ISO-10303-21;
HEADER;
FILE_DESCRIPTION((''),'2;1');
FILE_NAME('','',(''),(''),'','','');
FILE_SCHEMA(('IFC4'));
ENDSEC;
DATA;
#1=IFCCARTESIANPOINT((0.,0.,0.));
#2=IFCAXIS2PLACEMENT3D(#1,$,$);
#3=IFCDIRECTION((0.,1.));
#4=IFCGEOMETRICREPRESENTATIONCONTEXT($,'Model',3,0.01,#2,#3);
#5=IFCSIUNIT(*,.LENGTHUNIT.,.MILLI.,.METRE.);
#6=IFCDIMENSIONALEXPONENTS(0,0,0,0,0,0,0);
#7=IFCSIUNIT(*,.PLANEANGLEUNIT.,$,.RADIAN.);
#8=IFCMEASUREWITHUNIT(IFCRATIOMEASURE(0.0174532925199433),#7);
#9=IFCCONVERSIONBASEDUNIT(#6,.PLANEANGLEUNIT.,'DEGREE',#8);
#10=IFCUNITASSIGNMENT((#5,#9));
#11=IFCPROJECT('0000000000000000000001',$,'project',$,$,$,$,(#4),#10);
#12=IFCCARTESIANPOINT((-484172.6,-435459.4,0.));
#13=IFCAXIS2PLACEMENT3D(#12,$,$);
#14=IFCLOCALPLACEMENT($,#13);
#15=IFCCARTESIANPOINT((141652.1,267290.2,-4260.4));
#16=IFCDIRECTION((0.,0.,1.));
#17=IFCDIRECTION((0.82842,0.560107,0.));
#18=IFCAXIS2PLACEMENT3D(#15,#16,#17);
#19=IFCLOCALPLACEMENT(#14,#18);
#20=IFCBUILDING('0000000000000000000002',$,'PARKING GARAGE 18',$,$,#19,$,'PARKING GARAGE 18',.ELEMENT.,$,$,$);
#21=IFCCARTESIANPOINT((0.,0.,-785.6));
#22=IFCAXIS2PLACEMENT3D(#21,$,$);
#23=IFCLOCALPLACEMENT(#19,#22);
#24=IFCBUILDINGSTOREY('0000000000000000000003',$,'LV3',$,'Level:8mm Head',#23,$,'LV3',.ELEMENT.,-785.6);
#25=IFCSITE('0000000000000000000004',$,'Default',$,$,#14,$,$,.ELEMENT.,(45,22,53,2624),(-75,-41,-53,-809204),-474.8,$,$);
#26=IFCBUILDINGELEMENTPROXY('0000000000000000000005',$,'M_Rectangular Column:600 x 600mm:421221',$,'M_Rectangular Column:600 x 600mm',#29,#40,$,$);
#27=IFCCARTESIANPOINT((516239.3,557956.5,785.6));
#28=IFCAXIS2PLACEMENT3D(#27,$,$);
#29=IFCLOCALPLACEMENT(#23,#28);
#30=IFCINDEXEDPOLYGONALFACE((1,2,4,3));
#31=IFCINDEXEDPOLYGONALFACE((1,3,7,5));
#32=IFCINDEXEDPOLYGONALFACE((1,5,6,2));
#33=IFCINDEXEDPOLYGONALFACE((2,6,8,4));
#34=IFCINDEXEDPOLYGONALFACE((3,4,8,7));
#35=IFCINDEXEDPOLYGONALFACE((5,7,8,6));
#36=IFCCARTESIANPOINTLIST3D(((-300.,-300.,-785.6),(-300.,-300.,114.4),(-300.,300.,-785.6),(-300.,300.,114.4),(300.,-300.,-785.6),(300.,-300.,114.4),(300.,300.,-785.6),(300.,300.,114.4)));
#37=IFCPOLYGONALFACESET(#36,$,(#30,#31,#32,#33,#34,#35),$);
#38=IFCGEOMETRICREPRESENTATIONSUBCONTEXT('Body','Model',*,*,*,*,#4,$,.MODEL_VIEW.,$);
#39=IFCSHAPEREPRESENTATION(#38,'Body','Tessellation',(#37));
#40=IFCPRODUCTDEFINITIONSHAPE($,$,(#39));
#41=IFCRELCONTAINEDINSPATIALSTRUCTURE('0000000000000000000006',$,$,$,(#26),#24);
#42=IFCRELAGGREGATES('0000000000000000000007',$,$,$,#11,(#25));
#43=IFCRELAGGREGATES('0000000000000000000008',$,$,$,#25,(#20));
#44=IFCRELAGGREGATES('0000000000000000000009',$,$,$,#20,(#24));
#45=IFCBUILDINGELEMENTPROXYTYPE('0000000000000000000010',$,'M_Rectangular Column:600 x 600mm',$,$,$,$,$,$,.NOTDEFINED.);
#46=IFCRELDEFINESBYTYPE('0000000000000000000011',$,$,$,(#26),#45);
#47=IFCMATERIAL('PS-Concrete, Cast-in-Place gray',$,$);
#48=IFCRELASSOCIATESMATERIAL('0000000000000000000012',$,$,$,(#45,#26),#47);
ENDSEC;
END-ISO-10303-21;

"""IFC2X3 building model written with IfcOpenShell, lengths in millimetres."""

from ifc_helpers import new_model, entity, si_unit, converted_unit, direction, frame, origin, origin_2d_with_axis, place, context, subcontext, project, spatial, rectangle, extrude, source, transform, mapped, material, type_object, type_shapes, element, save


model = new_model("IFC2X3")

# Units and contexts
model_context = context("Model", 3, precision=0.01, world=origin(), true_north=direction((0.0, 1.0)))
body_context = subcontext(model_context, "Body", "Model", "MODEL_VIEW")
ifc_project = project(units=[si_unit("LENGTHUNIT", "METRE", prefix="MILLI"), converted_unit("PLANEANGLEUNIT", "DEGREE", entity("IfcRatioMeasure", 0.0174532925199433), si_unit("PLANEANGLEUNIT", "RADIAN"), dimensions=[0, 0, 0, 0, 0, 0, 0])], contexts=[model_context])

# Site, building, storey
site_placement = place(None, frame((-484172.6, -435459.4, 0.0)))
site = spatial("IfcSite", under=ifc_project, at=site_placement, Name="Default", CompositionType="ELEMENT", RefLatitude=(45, 22, 53, 2624), RefLongitude=(-75, -41, -53, -809204), RefElevation=-474.8)
building_placement = place(site_placement, frame((141652.1, 267290.2, -4260.4), z_axis=(0.0, 0.0, 1.0), x_axis=(0.82842, 0.560107, 0.0)))
building = spatial("IfcBuilding", under=site, at=building_placement, Name="PARKING GARAGE 18", LongName="PARKING GARAGE 18", CompositionType="ELEMENT")
storey_placement = place(building_placement, frame((0.0, 0.0, -785.6)))
storey = spatial("IfcBuildingStorey", under=building, at=storey_placement, Name="LV3", ObjectType="Level:8mm Head", LongName="LV3", CompositionType="ELEMENT", Elevation=-785.6)

# Shared definitions
ifc_material_1 = material(Name="PS-Concrete, Cast-in-Place gray")

# Building element proxy
building_element_proxy_type_1 = type_object("IfcBuildingElementProxyType", Name="M_Rectangular Column:600 x 600mm", PredefinedType="NOTDEFINED", material=ifc_material_1)
shared_shape_1 = source(origin(), body_context, "Body", "SweptSolid", [
    extrude(rectangle(XDim=600.0, YDim=600.0, at=origin_2d_with_axis()), frame((0.0, 0.0, -785.6), z_axis=(0.0, 0.0, 1.0), x_axis=(0.0, 1.0, 0.0)), (0.0, 0.0, 1.0), 900.0),
])
type_shapes(building_element_proxy_type_1, [shared_shape_1])
proxy_placement = place(storey_placement, frame((516239.3, 557956.5, 785.6)))
element("IfcBuildingElementProxy", 1, at=proxy_placement, inside=storey, type_object=building_element_proxy_type_1, material=ifc_material_1, Name="M_Rectangular Column:600 x 600mm:421221", ObjectType="M_Rectangular Column:600 x 600mm", context=body_context, shape_type="MappedRepresentation", body=[
    mapped(shared_shape_1, transform((0.0, 0.0, 0.0), scale=1.0)),
])

save(model, "model.ifc")
